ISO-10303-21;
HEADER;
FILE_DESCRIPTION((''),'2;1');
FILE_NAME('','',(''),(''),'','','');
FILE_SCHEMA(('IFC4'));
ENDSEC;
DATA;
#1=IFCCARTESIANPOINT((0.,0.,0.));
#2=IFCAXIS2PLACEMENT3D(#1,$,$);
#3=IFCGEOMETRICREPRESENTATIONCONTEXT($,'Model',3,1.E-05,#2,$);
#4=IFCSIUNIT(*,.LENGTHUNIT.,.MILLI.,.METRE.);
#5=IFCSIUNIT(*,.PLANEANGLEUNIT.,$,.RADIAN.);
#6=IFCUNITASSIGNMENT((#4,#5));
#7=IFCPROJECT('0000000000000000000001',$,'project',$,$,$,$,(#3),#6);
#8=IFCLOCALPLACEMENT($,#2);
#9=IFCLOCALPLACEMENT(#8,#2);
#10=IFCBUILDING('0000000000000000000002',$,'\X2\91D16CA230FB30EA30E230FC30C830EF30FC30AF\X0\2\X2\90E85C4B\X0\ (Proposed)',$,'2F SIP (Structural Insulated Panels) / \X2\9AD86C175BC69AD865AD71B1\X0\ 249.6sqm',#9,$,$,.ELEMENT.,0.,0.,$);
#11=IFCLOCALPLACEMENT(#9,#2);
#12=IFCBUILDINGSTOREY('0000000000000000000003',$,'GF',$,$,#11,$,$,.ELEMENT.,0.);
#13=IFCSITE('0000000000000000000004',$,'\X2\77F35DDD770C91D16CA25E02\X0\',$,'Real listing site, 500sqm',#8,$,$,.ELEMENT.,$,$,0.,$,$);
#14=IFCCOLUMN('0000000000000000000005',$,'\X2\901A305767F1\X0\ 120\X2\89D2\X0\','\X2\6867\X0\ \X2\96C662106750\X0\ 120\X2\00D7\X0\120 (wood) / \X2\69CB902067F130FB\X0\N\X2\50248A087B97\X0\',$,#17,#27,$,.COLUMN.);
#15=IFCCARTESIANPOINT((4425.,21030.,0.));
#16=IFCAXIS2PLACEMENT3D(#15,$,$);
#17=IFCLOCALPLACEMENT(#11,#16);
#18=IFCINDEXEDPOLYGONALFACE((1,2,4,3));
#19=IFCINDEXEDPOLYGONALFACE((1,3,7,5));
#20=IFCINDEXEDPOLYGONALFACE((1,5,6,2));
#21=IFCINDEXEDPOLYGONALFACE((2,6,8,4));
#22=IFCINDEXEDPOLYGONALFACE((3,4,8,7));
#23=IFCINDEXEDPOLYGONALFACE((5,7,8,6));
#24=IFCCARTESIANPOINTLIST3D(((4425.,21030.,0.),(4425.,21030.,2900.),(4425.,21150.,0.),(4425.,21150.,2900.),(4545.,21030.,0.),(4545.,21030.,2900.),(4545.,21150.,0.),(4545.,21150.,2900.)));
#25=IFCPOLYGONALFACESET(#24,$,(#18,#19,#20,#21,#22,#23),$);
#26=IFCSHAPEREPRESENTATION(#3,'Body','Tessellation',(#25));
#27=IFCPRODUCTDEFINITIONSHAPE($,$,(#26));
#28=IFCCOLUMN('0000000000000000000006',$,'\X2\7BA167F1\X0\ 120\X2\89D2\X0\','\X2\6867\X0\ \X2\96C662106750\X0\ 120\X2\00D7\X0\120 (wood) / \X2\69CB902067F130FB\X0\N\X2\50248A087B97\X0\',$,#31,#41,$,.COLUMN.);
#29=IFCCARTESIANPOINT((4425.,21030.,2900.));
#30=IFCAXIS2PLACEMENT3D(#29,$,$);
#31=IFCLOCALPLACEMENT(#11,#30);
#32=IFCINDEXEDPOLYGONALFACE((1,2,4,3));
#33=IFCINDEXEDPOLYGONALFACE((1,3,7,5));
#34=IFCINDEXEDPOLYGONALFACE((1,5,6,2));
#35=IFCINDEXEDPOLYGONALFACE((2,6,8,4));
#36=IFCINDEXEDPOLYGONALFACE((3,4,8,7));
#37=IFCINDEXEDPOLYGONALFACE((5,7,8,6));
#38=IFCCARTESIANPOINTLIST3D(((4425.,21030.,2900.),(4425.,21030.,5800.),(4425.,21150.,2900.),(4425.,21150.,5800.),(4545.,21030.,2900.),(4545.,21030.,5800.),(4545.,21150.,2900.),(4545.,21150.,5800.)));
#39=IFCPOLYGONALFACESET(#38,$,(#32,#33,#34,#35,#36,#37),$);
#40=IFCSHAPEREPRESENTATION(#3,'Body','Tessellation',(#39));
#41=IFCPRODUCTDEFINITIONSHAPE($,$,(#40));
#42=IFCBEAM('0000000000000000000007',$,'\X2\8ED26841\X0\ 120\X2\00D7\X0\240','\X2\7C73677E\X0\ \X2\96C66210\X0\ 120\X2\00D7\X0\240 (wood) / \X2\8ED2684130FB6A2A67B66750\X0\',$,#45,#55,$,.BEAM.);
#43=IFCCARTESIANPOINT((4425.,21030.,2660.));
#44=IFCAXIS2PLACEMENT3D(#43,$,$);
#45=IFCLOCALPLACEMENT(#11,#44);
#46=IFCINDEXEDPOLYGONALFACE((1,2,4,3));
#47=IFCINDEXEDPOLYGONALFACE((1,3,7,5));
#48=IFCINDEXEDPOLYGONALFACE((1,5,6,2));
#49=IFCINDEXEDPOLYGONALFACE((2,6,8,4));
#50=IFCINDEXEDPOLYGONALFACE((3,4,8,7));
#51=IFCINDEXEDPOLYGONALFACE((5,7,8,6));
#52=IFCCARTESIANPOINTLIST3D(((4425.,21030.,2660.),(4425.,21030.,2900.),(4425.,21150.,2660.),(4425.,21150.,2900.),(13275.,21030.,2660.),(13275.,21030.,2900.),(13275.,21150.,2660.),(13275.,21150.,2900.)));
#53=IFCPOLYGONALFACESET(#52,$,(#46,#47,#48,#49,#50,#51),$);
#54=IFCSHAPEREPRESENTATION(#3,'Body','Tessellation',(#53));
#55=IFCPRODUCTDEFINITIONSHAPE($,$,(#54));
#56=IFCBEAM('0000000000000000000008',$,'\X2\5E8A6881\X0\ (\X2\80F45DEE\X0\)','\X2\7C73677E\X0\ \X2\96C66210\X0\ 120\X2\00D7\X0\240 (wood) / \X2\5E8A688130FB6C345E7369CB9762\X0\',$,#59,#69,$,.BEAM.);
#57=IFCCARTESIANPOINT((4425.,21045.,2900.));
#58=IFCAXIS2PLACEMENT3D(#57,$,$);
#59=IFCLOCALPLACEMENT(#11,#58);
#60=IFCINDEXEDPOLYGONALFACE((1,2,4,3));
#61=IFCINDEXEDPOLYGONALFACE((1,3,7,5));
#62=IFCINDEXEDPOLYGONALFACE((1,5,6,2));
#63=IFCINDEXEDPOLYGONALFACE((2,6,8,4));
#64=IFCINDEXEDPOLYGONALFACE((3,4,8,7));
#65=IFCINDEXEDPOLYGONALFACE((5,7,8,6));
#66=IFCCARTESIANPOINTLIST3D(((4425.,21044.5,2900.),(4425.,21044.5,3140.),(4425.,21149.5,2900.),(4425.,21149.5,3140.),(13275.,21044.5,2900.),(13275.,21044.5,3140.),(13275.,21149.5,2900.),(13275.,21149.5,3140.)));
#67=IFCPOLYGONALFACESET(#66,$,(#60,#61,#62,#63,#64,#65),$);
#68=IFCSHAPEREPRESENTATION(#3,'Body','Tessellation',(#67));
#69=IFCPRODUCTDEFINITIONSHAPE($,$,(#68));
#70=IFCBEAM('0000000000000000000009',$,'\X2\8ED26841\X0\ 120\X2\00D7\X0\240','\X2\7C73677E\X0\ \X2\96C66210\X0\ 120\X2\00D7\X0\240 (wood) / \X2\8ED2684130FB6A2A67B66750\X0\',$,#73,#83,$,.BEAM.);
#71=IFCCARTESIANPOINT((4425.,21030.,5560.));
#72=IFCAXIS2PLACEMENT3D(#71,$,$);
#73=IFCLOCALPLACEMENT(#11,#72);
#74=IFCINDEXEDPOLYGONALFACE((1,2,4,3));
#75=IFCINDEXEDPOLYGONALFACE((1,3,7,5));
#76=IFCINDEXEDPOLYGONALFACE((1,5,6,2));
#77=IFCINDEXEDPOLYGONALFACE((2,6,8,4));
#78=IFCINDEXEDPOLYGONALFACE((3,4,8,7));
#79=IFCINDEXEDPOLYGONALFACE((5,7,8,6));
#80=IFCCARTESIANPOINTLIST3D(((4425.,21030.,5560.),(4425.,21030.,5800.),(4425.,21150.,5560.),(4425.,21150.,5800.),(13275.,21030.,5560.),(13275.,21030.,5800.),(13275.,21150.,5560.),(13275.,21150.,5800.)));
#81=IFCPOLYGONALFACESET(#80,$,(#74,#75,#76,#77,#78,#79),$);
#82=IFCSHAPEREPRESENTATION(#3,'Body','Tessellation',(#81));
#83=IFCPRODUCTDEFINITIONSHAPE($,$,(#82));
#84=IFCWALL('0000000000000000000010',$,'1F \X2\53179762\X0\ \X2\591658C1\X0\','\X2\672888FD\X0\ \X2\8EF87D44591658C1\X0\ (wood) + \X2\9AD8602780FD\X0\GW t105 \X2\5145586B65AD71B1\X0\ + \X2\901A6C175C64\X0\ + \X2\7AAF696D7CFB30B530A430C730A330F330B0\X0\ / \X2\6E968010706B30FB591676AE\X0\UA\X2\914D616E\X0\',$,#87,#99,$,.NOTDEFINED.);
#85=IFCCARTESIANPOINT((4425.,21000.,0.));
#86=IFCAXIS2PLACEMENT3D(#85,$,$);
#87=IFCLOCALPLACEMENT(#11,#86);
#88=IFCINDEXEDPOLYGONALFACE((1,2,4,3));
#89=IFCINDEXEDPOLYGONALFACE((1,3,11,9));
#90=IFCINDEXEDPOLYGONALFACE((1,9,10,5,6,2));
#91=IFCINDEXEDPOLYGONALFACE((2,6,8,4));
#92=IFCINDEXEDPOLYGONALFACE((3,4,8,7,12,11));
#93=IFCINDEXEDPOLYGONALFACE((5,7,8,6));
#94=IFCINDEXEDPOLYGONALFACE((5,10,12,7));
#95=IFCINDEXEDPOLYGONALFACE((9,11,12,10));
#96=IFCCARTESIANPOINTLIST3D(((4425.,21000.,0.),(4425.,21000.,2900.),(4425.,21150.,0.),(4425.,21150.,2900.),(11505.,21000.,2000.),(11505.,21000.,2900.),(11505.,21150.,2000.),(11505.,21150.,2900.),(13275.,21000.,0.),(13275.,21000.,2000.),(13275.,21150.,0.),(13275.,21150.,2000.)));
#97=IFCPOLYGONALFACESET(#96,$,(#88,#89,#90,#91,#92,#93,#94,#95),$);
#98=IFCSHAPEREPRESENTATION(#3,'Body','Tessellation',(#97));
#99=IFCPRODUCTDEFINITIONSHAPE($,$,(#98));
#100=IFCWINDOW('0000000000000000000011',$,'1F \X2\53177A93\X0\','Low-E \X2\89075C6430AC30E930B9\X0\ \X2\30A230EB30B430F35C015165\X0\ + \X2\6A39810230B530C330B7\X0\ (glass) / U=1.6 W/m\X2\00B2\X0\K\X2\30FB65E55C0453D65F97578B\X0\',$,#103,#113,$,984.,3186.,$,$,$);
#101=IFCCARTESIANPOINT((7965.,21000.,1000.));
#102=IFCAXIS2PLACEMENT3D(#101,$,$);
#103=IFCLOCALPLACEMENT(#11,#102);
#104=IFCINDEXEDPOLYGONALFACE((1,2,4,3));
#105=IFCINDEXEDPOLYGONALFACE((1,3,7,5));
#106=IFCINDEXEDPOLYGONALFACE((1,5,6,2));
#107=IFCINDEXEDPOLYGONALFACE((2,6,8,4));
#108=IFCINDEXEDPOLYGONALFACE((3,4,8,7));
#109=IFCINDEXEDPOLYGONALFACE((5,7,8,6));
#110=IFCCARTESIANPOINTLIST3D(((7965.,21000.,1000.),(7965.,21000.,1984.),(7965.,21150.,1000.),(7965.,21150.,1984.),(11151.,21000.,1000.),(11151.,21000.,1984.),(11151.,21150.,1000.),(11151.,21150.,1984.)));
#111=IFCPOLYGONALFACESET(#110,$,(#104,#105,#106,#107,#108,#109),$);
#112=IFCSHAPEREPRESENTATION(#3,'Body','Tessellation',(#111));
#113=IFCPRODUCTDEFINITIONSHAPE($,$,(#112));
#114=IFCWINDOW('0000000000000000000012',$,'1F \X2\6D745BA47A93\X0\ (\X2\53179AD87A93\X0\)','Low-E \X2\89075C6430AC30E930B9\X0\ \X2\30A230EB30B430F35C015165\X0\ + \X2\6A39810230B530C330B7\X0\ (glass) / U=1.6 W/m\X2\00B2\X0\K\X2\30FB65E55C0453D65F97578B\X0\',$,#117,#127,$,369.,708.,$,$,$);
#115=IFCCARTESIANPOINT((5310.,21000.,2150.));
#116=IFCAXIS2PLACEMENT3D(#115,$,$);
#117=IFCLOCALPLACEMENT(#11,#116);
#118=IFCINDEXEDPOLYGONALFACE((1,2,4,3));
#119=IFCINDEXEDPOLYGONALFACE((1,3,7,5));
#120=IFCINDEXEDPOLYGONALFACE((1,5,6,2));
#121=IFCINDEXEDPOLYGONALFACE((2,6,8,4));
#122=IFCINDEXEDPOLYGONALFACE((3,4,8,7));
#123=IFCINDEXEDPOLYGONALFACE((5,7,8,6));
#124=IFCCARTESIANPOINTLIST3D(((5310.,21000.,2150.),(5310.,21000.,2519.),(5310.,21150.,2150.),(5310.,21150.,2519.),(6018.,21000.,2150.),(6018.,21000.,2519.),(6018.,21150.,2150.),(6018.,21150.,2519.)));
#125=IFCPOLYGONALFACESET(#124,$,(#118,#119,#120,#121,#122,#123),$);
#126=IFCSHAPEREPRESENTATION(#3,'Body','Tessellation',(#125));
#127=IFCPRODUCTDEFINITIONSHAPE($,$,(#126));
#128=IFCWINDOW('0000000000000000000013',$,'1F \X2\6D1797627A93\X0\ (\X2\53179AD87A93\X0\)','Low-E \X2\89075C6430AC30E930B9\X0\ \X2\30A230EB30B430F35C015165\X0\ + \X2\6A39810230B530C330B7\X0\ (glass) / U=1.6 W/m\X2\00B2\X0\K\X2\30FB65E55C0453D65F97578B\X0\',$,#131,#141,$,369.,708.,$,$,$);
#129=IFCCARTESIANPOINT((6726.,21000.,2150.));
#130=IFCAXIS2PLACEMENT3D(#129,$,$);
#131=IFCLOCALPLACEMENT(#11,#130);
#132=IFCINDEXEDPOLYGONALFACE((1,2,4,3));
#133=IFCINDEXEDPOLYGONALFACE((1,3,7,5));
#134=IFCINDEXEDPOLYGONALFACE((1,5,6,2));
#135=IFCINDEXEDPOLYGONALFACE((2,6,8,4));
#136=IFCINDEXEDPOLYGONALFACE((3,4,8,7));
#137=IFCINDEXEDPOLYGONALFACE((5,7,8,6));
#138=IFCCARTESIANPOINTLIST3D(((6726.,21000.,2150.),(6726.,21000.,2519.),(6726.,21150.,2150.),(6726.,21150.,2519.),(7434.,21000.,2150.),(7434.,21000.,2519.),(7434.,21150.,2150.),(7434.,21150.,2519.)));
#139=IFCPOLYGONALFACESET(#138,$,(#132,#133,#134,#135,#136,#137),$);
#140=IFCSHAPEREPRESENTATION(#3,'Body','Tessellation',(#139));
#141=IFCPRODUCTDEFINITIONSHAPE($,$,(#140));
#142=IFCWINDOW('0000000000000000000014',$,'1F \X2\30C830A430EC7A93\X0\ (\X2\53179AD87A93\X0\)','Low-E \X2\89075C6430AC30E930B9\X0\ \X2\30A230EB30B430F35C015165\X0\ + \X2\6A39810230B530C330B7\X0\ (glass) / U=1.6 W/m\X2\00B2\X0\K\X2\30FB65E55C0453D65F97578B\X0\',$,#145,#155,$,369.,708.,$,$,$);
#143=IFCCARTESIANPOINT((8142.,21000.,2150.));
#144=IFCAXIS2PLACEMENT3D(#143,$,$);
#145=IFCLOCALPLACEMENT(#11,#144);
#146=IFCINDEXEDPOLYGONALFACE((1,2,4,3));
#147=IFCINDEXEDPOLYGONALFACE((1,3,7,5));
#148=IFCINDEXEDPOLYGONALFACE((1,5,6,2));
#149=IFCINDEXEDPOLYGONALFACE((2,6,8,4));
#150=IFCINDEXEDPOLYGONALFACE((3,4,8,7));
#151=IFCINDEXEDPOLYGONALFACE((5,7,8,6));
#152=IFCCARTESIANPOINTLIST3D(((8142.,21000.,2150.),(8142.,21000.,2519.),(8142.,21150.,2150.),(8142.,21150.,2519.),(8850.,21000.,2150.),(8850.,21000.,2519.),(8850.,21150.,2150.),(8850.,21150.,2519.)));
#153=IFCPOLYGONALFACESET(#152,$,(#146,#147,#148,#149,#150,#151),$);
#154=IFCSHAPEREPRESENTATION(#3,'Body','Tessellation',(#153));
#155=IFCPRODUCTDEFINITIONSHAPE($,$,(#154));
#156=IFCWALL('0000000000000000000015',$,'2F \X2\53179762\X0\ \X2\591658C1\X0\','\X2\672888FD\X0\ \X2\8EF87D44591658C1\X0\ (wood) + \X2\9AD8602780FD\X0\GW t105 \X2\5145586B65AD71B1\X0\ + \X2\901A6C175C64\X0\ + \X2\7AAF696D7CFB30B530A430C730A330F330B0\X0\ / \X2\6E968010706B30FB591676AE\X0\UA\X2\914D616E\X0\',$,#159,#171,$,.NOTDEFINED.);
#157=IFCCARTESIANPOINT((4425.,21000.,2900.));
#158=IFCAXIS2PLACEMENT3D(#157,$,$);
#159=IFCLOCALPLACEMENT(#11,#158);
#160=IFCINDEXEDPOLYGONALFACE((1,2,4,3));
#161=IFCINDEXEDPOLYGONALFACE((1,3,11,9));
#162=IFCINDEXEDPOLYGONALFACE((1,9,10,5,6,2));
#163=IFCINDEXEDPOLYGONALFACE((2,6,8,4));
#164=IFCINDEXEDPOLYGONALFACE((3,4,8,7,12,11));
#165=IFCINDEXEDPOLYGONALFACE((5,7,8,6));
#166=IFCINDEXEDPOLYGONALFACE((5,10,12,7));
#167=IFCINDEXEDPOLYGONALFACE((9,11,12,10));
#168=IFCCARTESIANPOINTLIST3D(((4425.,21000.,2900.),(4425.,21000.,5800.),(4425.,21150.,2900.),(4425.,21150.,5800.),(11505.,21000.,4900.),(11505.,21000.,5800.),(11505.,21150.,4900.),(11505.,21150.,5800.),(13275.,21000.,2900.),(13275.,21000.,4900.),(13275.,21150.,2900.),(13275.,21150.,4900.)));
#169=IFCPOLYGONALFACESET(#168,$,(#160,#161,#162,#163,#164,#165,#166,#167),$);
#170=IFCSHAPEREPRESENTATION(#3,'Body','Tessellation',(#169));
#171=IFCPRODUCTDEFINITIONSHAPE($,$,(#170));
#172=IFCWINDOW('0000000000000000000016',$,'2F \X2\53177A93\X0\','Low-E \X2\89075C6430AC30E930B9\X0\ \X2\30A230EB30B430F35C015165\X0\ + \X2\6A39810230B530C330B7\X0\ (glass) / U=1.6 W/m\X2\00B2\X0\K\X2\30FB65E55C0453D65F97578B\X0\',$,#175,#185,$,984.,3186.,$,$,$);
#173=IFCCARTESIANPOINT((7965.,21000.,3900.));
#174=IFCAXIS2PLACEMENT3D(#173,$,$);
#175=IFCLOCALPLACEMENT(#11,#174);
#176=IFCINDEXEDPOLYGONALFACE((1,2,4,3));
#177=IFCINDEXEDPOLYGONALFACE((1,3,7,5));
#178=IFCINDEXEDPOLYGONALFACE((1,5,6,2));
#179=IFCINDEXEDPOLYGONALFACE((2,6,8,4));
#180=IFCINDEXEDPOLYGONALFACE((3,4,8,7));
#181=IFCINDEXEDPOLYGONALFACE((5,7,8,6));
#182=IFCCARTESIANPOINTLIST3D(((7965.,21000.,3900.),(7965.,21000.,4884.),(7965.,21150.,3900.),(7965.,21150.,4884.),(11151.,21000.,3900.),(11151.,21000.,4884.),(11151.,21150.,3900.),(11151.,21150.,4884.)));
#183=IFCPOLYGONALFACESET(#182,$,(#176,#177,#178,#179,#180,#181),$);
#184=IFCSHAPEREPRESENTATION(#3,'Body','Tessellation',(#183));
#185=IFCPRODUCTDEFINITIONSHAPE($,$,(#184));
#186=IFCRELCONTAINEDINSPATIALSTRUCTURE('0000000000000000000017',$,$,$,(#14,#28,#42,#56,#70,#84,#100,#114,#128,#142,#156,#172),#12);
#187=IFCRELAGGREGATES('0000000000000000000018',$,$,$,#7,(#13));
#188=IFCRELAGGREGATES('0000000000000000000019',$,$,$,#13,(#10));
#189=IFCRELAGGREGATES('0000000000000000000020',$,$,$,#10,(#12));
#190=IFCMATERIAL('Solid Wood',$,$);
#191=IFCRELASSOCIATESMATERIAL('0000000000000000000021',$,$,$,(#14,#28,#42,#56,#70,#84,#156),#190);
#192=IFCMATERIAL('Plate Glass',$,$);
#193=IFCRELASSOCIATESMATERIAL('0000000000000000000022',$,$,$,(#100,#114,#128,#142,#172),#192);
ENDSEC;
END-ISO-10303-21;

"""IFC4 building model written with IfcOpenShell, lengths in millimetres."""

from ifc_helpers import new_model, si_unit, frame, frame_2d, origin, place, context, project, spatial, rectangle, extrude, material, element, fill, save


model = new_model("IFC4")

# Units and contexts
model_context = context("Model", 3, precision=1e-05, world=origin())
ifc_project = project(units=[si_unit("LENGTHUNIT", "METRE", prefix="MILLI"), si_unit("PLANEANGLEUNIT", "RADIAN")], contexts=[model_context])

# Site, building, storey
site_placement = place(None, origin())
site = spatial("IfcSite", under=ifc_project, at=site_placement, Name="石川県金沢市", ObjectType="Real listing site, 500sqm", CompositionType="ELEMENT", RefElevation=0.0)
building_placement = place(site_placement, origin())
building = spatial("IfcBuilding", under=site, at=building_placement, Name="金沢・リモートワーク2部屋 (Proposed)", ObjectType="2F SIP (Structural Insulated Panels) / 高気密高断熱 249.6sqm", CompositionType="ELEMENT", ElevationOfRefHeight=0.0, ElevationOfTerrain=0.0)
storey_placement = place(building_placement, origin())
storey = spatial("IfcBuildingStorey", under=building, at=storey_placement, Name="GF", CompositionType="ELEMENT", Elevation=0.0)

# Columns
ifc_material_1 = material(Name="Solid Wood")
column_1_placement = place(storey_placement, frame((4425.0, 21030.0, 0.0)))
element("IfcColumn", 1, at=column_1_placement, inside=storey, material=ifc_material_1, Name="通し柱 120角", Description="桧 集成材 120×120 (wood) / 構造柱・N値計算", PredefinedType="COLUMN", context=model_context, shape_type="SweptSolid", body=[
    extrude(rectangle(XDim=120.0, YDim=120.0, at=frame_2d((60.0, 60.0))), frame((4425.0, 21030.0, 0.0)), (0.0, 0.0, 1.0), 2900.0),
])
column_2_placement = place(storey_placement, frame((4425.0, 21030.0, 2900.0)))
element("IfcColumn", 2, at=column_2_placement, inside=storey, material=ifc_material_1, Name="管柱 120角", Description="桧 集成材 120×120 (wood) / 構造柱・N値計算", PredefinedType="COLUMN", context=model_context, shape_type="SweptSolid", body=[
    extrude(rectangle(XDim=120.0, YDim=120.0, at=frame_2d((60.0, 60.0))), frame((4425.0, 21030.0, 2900.0)), (0.0, 0.0, 1.0), 2900.0),
])

# Beams
beam_1_placement = place(storey_placement, frame((4425.0, 21030.0, 2660.0)))
element("IfcBeam", 3, at=beam_1_placement, inside=storey, material=ifc_material_1, Name="軒桁 120×240", Description="米松 集成 120×240 (wood) / 軒桁・横架材", PredefinedType="BEAM", context=model_context, shape_type="SweptSolid", body=[
    extrude(rectangle(XDim=8850.0, YDim=120.0, at=frame_2d((4425.0, 60.0))), frame((4425.0, 21030.0, 2660.0)), (0.0, 0.0, 1.0), 240.0),
])
beam_2_placement = place(storey_placement, frame((4425.0, 21045.0, 2900.0)))
element("IfcBeam", 4, at=beam_2_placement, inside=storey, material=ifc_material_1, Name="床梁 (胴差)", Description="米松 集成 120×240 (wood) / 床梁・水平構面", PredefinedType="BEAM", context=model_context, shape_type="SweptSolid", body=[
    extrude(rectangle(XDim=8850.0, YDim=105.0, at=frame_2d((4425.0, 52.0))), frame((4425.0, 21045.0, 2900.0)), (0.0, 0.0, 1.0), 240.0),
])
beam_3_placement = place(storey_placement, frame((4425.0, 21030.0, 5560.0)))
element("IfcBeam", 5, at=beam_3_placement, inside=storey, material=ifc_material_1, Name="軒桁 120×240", Description="米松 集成 120×240 (wood) / 軒桁・横架材", PredefinedType="BEAM", context=model_context, shape_type="SweptSolid", body=[
    extrude(rectangle(XDim=8850.0, YDim=120.0, at=frame_2d((4425.0, 60.0))), frame((4425.0, 21030.0, 5560.0)), (0.0, 0.0, 1.0), 240.0),
])

# Wall, openings, windows
wall_1_placement = place(storey_placement, frame((4425.0, 21000.0, 0.0)))
wall_1 = element("IfcWall", 6, at=wall_1_placement, inside=storey, material=ifc_material_1, Name="1F 北面 外壁", Description="木製 軸組外壁 (wood) + 高性能GW t105 充填断熱 + 通気層 + 窯業系サイディング / 準耐火・外皮UA配慮", PredefinedType="NOTDEFINED", context=model_context, shape_type="SweptSolid", body=[
    extrude(rectangle(XDim=8850.0, YDim=150.0, at=frame_2d((4425.0, 75.0))), frame((4425.0, 21000.0, 0.0)), (0.0, 0.0, 1.0), 2900.0),
])
opening_1_placement = place(storey_placement, frame((7965.0, 21000.0, 1000.0)))
opening_1 = element("IfcOpeningElement", 7, at=opening_1_placement, cuts=wall_1, PredefinedType="NOTDEFINED", context=model_context, shape_type="SweptSolid", body=[
    extrude(rectangle(XDim=3186.0, YDim=150.0, at=frame_2d((1593.0, 75.0))), frame((7965.0, 21000.0, 1000.0)), (0.0, 0.0, 1.0), 984.0),
])
opening_2_placement = place(storey_placement, frame((5310.0, 21000.0, 2150.0)))
opening_2 = element("IfcOpeningElement", 8, at=opening_2_placement, cuts=wall_1, PredefinedType="NOTDEFINED", context=model_context, shape_type="SweptSolid", body=[
    extrude(rectangle(XDim=708.0, YDim=150.0, at=frame_2d((354.0, 75.0))), frame((5310.0, 21000.0, 2150.0)), (0.0, 0.0, 1.0), 369.0),
])
opening_3_placement = place(storey_placement, frame((6726.0, 21000.0, 2150.0)))
opening_3 = element("IfcOpeningElement", 9, at=opening_3_placement, cuts=wall_1, PredefinedType="NOTDEFINED", context=model_context, shape_type="SweptSolid", body=[
    extrude(rectangle(XDim=708.0, YDim=150.0, at=frame_2d((354.0, 75.0))), frame((6726.0, 21000.0, 2150.0)), (0.0, 0.0, 1.0), 369.0),
])
opening_4_placement = place(storey_placement, frame((8142.0, 21000.0, 2150.0)))
opening_4 = element("IfcOpeningElement", 10, at=opening_4_placement, cuts=wall_1, PredefinedType="NOTDEFINED", context=model_context, shape_type="SweptSolid", body=[
    extrude(rectangle(XDim=708.0, YDim=150.0, at=frame_2d((354.0, 75.0))), frame((8142.0, 21000.0, 2150.0)), (0.0, 0.0, 1.0), 369.0),
])
ifc_material_2 = material(Name="Plate Glass")
window_1_placement = place(storey_placement, frame((7965.0, 21000.0, 1000.0)))
window_1 = element("IfcWindow", 11, at=window_1_placement, inside=storey, material=ifc_material_2, Name="1F 北窓", Description="Low-E 複層ガラス アルゴン封入 + 樹脂サッシ (glass) / U=1.6 W/m²K・日射取得型", OverallHeight=984.0, OverallWidth=3186.0, context=model_context, shape_type="SweptSolid", body=[
    extrude(rectangle(XDim=3186.0, YDim=150.0, at=frame_2d((1593.0, 75.0))), frame((7965.0, 21000.0, 1000.0)), (0.0, 0.0, 1.0), 984.0),
])
fill(opening_1, window_1)
window_2_placement = place(storey_placement, frame((5310.0, 21000.0, 2150.0)))
window_2 = element("IfcWindow", 12, at=window_2_placement, inside=storey, material=ifc_material_2, Name="1F 浴室窓 (北高窓)", Description="Low-E 複層ガラス アルゴン封入 + 樹脂サッシ (glass) / U=1.6 W/m²K・日射取得型", OverallHeight=369.0, OverallWidth=708.0, context=model_context, shape_type="SweptSolid", body=[
    extrude(rectangle(XDim=708.0, YDim=150.0, at=frame_2d((354.0, 75.0))), frame((5310.0, 21000.0, 2150.0)), (0.0, 0.0, 1.0), 369.0),
])
fill(opening_2, window_2)
window_3_placement = place(storey_placement, frame((6726.0, 21000.0, 2150.0)))
window_3 = element("IfcWindow", 13, at=window_3_placement, inside=storey, material=ifc_material_2, Name="1F 洗面窓 (北高窓)", Description="Low-E 複層ガラス アルゴン封入 + 樹脂サッシ (glass) / U=1.6 W/m²K・日射取得型", OverallHeight=369.0, OverallWidth=708.0, context=model_context, shape_type="SweptSolid", body=[
    extrude(rectangle(XDim=708.0, YDim=150.0, at=frame_2d((354.0, 75.0))), frame((6726.0, 21000.0, 2150.0)), (0.0, 0.0, 1.0), 369.0),
])
fill(opening_3, window_3)
window_4_placement = place(storey_placement, frame((8142.0, 21000.0, 2150.0)))
window_4 = element("IfcWindow", 14, at=window_4_placement, inside=storey, material=ifc_material_2, Name="1F トイレ窓 (北高窓)", Description="Low-E 複層ガラス アルゴン封入 + 樹脂サッシ (glass) / U=1.6 W/m²K・日射取得型", OverallHeight=369.0, OverallWidth=708.0, context=model_context, shape_type="SweptSolid", body=[
    extrude(rectangle(XDim=708.0, YDim=150.0, at=frame_2d((354.0, 75.0))), frame((8142.0, 21000.0, 2150.0)), (0.0, 0.0, 1.0), 369.0),
])
fill(opening_4, window_4)

# Wall, opening, window
wall_2_placement = place(storey_placement, frame((4425.0, 21000.0, 2900.0)))
wall_2 = element("IfcWall", 15, at=wall_2_placement, inside=storey, material=ifc_material_1, Name="2F 北面 外壁", Description="木製 軸組外壁 (wood) + 高性能GW t105 充填断熱 + 通気層 + 窯業系サイディング / 準耐火・外皮UA配慮", PredefinedType="NOTDEFINED", context=model_context, shape_type="SweptSolid", body=[
    extrude(rectangle(XDim=8850.0, YDim=150.0, at=frame_2d((4425.0, 75.0))), frame((4425.0, 21000.0, 2900.0)), (0.0, 0.0, 1.0), 2900.0),
])
opening_5_placement = place(storey_placement, frame((7965.0, 21000.0, 3900.0)))
opening_5 = element("IfcOpeningElement", 16, at=opening_5_placement, cuts=wall_2, PredefinedType="NOTDEFINED", context=model_context, shape_type="SweptSolid", body=[
    extrude(rectangle(XDim=3186.0, YDim=150.0, at=frame_2d((1593.0, 75.0))), frame((7965.0, 21000.0, 3900.0)), (0.0, 0.0, 1.0), 984.0),
])
window_5_placement = place(storey_placement, frame((7965.0, 21000.0, 3900.0)))
window_5 = element("IfcWindow", 17, at=window_5_placement, inside=storey, material=ifc_material_2, Name="2F 北窓", Description="Low-E 複層ガラス アルゴン封入 + 樹脂サッシ (glass) / U=1.6 W/m²K・日射取得型", OverallHeight=984.0, OverallWidth=3186.0, context=model_context, shape_type="SweptSolid", body=[
    extrude(rectangle(XDim=3186.0, YDim=150.0, at=frame_2d((1593.0, 75.0))), frame((7965.0, 21000.0, 3900.0)), (0.0, 0.0, 1.0), 984.0),
])
fill(opening_5, window_5)

save(model, "model.ifc")
